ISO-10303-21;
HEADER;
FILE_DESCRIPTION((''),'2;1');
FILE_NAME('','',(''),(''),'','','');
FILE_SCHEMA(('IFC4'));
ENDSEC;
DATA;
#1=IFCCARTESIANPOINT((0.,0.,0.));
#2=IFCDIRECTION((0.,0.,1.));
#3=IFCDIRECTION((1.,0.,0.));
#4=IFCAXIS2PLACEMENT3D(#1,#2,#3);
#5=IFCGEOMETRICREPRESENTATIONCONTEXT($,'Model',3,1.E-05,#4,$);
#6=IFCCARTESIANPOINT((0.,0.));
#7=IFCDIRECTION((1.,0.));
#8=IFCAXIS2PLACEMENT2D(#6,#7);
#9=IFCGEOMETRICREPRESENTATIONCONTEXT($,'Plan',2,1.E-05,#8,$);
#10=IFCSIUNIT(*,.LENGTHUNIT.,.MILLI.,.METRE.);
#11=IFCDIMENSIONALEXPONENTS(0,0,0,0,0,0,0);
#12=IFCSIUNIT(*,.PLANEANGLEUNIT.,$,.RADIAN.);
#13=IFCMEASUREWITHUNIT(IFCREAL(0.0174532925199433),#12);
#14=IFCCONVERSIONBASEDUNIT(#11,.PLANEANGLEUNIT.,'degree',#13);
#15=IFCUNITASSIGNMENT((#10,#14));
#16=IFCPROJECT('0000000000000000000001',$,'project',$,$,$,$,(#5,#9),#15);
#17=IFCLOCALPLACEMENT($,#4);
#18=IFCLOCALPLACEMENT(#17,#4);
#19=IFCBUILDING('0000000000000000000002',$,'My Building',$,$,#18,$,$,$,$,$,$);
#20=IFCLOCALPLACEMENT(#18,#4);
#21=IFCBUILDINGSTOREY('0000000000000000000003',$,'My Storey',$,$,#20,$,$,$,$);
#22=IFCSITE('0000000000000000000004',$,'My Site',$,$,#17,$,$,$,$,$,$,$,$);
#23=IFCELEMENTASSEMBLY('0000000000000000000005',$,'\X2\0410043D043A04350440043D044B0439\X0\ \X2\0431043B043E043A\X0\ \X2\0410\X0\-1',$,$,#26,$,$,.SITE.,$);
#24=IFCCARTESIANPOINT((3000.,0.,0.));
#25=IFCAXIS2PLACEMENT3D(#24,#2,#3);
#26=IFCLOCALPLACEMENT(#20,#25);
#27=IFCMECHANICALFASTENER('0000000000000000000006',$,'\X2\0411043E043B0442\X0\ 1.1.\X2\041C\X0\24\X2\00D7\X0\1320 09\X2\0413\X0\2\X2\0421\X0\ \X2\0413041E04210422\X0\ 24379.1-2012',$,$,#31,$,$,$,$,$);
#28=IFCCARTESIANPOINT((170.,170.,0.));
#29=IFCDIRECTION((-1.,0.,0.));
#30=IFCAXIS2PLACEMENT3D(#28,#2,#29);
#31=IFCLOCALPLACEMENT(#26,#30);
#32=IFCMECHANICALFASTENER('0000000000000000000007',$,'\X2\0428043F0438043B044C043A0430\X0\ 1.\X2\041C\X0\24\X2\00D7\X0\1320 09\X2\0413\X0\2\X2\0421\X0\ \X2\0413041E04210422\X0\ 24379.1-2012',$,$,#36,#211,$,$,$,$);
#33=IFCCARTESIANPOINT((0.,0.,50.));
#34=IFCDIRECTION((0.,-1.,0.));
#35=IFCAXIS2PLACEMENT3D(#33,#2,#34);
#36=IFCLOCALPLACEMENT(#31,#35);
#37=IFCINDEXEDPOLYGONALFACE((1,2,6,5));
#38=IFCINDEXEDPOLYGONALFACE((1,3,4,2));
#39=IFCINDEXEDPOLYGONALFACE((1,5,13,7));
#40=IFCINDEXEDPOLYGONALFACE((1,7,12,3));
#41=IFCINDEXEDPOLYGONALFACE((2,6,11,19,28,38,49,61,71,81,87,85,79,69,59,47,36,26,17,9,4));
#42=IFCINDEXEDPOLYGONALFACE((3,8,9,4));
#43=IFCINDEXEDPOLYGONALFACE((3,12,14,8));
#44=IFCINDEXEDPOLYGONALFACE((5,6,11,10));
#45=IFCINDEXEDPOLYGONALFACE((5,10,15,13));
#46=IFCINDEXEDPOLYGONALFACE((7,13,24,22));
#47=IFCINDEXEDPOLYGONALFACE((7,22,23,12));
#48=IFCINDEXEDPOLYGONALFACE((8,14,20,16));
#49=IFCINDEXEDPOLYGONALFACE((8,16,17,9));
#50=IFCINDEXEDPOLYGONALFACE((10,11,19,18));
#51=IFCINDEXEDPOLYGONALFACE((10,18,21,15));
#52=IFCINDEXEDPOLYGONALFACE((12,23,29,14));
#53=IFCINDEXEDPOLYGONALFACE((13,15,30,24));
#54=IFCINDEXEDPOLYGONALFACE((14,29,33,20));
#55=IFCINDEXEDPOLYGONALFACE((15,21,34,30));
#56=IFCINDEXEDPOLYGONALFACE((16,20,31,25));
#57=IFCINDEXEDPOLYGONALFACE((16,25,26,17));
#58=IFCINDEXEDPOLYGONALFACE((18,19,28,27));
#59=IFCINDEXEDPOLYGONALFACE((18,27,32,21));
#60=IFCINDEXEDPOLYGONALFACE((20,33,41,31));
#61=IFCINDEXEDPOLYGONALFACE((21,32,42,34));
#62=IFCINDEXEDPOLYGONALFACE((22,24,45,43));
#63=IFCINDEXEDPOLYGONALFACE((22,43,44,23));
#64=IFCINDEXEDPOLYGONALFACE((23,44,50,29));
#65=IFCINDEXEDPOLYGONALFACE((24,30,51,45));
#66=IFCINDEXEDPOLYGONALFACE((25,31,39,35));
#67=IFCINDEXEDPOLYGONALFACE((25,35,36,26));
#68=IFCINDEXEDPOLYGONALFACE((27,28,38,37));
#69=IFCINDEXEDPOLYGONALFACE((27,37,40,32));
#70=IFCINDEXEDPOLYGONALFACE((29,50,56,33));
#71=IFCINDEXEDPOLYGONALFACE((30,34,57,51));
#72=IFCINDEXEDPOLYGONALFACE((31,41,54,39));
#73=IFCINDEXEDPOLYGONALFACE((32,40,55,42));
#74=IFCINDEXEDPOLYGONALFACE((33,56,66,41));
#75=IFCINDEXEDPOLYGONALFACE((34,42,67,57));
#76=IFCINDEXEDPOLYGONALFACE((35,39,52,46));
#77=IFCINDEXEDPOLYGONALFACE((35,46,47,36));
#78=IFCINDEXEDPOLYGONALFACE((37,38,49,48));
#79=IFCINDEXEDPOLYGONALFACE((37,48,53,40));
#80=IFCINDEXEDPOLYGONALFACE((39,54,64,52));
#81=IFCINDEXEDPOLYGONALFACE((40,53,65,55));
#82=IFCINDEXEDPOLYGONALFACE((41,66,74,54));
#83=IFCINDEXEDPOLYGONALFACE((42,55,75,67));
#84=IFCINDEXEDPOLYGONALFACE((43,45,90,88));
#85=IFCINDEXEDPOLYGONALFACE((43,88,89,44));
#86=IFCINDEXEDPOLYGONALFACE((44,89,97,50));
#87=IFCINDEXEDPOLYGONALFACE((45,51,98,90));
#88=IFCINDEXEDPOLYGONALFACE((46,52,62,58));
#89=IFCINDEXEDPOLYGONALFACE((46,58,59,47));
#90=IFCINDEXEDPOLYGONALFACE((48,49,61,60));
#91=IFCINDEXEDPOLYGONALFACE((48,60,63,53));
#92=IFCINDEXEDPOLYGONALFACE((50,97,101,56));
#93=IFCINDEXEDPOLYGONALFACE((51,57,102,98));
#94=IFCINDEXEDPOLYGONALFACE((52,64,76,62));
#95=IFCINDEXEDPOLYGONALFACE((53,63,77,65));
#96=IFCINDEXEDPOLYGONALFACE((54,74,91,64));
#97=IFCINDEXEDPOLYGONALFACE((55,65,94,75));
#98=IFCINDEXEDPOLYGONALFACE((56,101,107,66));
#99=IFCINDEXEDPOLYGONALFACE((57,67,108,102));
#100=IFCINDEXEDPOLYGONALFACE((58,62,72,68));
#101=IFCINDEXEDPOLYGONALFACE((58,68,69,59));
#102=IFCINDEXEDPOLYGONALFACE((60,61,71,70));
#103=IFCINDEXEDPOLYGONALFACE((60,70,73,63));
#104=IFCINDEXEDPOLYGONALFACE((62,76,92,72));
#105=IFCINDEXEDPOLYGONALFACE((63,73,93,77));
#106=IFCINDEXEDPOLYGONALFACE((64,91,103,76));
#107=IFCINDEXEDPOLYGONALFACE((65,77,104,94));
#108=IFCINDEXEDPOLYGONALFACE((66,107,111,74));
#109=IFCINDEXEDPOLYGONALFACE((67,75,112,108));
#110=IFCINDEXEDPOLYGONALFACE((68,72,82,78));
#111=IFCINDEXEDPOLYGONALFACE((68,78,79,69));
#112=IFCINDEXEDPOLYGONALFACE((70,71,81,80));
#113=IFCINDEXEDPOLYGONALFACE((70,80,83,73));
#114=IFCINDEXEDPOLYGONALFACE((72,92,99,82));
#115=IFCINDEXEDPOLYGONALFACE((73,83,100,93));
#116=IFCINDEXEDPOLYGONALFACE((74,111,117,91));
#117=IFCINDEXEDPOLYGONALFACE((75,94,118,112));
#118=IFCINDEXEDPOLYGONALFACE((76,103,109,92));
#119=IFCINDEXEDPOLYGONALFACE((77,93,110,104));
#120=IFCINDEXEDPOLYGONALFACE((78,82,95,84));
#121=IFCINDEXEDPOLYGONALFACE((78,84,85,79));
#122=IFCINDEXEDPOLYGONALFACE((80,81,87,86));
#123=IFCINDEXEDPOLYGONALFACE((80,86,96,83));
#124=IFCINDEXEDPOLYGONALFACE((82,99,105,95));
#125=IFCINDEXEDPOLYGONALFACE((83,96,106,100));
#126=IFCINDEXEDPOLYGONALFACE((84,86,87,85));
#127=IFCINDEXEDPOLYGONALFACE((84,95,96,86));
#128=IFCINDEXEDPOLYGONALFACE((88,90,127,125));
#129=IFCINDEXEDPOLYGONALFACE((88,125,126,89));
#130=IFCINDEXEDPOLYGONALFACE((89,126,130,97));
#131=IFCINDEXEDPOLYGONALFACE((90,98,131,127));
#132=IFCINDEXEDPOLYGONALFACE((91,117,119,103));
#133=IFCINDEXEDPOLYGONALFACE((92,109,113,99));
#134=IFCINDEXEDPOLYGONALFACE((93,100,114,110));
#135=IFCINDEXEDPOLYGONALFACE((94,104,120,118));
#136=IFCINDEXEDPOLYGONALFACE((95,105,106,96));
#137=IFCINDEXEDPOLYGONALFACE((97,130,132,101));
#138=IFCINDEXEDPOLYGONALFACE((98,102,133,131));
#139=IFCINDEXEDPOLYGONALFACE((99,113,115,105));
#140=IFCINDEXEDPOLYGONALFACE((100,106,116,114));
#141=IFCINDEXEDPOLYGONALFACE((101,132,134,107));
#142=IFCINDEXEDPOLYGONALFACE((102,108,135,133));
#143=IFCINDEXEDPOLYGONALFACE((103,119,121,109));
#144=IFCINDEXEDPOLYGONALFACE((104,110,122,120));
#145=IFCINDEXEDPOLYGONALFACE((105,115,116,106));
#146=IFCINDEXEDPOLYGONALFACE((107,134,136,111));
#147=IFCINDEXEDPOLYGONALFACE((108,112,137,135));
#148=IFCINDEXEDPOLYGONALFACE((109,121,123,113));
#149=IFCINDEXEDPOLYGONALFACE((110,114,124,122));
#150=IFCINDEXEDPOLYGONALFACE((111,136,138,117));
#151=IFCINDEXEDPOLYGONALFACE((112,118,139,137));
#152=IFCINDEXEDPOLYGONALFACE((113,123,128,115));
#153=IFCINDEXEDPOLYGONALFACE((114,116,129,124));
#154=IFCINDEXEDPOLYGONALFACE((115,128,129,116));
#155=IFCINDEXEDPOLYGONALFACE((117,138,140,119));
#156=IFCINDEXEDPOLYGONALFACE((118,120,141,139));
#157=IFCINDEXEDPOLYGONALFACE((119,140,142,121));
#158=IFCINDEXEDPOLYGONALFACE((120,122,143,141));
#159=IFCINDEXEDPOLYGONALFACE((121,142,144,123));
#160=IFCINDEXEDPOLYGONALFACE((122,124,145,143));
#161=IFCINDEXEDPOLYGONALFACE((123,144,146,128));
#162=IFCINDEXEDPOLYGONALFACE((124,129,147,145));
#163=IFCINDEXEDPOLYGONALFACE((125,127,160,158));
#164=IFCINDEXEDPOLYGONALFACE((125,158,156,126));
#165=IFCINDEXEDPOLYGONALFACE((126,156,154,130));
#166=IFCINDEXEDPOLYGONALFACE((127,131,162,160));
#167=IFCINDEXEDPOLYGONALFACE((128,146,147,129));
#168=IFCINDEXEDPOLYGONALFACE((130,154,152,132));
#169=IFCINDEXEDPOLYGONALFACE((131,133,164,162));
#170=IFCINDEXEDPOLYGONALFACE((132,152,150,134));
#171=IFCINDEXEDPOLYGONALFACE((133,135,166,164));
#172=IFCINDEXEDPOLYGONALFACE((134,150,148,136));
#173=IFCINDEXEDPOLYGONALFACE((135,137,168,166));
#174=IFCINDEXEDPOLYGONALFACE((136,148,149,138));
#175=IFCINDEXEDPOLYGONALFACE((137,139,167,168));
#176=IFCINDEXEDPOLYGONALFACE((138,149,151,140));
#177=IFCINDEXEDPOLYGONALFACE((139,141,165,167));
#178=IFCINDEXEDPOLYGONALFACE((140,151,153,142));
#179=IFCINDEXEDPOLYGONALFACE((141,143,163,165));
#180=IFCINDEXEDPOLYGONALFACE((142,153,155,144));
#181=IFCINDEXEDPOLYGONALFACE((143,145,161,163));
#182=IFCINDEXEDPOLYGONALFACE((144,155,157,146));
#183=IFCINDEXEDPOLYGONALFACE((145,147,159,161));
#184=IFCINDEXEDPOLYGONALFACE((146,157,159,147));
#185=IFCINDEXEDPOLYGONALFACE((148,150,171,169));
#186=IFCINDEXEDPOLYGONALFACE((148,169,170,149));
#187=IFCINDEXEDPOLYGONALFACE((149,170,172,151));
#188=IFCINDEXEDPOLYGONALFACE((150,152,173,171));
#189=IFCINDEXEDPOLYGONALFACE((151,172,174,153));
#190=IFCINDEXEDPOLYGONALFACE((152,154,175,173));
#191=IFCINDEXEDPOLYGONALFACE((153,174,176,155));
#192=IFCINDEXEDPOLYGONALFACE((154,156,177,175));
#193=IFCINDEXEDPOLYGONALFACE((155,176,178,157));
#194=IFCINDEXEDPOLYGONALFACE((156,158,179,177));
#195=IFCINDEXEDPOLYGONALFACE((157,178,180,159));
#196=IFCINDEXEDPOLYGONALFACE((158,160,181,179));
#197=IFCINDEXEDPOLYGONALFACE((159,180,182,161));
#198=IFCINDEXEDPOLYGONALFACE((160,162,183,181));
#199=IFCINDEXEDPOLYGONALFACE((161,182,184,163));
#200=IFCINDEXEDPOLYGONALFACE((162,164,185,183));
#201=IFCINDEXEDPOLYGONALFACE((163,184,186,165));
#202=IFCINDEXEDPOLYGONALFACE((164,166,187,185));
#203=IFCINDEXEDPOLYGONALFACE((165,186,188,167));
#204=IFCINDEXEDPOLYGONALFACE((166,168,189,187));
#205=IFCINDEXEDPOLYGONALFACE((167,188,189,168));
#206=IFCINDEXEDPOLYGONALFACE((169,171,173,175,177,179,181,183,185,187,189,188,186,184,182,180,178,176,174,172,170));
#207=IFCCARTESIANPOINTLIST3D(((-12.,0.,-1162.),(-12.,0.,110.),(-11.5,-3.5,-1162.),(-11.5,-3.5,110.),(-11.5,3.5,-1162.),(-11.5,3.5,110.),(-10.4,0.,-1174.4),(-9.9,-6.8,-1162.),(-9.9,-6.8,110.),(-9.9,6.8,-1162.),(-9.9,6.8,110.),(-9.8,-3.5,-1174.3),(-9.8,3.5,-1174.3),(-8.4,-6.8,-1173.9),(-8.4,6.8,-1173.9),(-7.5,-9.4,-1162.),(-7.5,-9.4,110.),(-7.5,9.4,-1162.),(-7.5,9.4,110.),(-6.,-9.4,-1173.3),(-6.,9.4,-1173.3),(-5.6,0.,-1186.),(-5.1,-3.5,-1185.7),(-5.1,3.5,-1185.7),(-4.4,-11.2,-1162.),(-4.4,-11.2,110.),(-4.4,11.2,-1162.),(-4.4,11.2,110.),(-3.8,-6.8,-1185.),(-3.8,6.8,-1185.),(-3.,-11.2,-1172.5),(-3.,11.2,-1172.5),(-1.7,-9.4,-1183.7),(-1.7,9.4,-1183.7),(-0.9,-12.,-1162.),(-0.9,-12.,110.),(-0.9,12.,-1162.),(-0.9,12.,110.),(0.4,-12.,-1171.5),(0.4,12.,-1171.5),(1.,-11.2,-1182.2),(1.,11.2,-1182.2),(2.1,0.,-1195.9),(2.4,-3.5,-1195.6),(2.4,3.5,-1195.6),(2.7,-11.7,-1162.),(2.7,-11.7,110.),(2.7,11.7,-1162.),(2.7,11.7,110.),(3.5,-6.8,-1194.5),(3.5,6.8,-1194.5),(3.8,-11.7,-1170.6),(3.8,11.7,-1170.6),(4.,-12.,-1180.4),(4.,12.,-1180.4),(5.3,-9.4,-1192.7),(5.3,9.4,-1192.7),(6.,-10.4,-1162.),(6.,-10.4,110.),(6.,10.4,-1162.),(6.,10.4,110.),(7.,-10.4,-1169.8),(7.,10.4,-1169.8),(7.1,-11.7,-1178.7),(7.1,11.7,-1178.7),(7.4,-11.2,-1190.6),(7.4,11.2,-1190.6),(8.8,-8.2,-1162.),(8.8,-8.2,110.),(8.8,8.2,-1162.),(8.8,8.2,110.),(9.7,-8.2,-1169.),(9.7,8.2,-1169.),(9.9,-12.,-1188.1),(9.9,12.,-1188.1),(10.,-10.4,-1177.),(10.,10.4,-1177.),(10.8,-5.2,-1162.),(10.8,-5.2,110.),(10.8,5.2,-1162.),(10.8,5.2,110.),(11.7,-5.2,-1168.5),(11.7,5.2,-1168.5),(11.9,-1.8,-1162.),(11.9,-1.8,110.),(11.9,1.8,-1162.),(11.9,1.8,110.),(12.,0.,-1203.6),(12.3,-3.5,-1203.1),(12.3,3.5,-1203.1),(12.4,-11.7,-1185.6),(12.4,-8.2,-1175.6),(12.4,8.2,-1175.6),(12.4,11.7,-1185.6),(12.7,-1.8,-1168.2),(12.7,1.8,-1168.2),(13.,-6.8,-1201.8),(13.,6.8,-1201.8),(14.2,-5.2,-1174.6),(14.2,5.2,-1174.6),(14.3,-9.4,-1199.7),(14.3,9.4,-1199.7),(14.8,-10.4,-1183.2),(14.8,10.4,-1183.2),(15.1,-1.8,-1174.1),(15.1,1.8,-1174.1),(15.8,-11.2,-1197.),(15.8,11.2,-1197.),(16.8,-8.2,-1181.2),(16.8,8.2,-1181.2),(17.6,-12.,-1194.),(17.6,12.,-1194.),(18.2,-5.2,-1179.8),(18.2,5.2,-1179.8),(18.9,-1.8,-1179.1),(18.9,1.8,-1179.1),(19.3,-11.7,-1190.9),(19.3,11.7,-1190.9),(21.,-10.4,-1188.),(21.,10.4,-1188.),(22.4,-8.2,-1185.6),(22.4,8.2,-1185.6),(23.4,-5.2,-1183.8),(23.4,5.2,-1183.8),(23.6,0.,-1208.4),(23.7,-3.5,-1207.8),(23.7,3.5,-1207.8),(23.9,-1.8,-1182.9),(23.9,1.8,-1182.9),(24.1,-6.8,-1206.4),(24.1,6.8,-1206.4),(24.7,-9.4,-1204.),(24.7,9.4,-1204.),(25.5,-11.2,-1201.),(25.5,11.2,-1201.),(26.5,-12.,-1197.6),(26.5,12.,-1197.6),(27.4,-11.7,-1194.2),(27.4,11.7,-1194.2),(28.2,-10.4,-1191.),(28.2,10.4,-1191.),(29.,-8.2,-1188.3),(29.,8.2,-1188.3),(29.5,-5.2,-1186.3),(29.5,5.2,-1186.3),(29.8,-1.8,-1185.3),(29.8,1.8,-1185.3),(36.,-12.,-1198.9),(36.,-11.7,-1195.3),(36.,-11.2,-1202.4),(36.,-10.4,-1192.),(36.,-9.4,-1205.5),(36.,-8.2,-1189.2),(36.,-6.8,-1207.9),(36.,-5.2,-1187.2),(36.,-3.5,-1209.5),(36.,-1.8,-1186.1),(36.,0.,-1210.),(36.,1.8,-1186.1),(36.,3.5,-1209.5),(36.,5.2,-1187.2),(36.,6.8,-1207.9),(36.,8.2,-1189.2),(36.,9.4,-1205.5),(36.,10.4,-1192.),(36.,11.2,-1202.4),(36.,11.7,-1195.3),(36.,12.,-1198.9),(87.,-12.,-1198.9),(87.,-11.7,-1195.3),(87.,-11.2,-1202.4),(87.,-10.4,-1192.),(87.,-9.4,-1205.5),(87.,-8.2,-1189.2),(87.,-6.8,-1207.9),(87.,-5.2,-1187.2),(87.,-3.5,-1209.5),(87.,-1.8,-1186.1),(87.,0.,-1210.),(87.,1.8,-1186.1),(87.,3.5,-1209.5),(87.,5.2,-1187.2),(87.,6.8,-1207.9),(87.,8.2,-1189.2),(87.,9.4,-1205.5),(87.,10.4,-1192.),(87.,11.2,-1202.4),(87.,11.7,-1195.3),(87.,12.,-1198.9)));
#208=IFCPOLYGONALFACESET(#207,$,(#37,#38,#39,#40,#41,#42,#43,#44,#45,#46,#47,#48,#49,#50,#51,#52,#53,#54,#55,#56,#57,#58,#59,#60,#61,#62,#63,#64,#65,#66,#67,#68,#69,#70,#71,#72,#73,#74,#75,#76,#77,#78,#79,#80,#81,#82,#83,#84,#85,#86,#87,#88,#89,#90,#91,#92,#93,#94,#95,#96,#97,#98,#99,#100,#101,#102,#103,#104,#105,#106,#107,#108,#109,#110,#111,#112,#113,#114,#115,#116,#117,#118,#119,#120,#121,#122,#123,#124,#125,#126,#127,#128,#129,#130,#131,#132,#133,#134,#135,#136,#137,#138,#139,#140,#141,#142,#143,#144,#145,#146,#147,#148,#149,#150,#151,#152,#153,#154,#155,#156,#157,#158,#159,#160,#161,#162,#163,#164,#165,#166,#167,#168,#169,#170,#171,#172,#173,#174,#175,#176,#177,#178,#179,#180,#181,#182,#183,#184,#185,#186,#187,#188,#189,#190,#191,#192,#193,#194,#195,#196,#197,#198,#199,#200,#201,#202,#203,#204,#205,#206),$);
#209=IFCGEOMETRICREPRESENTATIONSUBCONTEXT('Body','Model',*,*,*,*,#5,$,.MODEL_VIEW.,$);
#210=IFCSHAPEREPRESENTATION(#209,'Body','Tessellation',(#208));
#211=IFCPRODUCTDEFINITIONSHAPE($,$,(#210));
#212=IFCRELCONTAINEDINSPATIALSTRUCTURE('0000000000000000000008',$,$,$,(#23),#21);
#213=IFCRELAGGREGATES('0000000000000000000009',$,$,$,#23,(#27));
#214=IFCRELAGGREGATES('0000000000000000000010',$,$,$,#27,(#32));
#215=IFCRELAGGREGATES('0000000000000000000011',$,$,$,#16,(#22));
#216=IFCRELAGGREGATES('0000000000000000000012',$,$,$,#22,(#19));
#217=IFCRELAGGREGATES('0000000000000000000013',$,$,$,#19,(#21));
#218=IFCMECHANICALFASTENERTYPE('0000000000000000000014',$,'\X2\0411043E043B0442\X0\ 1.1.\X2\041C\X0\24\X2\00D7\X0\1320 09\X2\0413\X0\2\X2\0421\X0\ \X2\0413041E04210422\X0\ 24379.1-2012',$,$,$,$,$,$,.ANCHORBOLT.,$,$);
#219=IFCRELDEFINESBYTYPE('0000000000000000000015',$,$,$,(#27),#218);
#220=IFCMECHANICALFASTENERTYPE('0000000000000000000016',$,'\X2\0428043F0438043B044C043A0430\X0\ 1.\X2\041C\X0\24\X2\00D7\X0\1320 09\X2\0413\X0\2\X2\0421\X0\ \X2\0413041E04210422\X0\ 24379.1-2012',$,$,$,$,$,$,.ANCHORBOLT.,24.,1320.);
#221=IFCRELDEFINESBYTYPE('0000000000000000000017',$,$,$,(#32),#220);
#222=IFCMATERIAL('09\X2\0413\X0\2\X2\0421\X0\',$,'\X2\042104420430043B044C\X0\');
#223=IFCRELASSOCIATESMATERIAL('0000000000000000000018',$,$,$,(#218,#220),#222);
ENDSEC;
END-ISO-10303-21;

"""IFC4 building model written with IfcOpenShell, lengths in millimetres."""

from ifc_helpers import new_model, entity, si_unit, converted_unit, frame, origin_with_axes, origin_2d_with_axis, place, context, subcontext, project, spatial, source, transform, mapped, material, type_object, type_shapes, element, aggregate, save


model = new_model("IFC4")

# Units and contexts
model_context = context("Model", 3, precision=1e-05, world=origin_with_axes())
plan_context = context("Plan", 2, precision=1e-05, world=origin_2d_with_axis())
body_context = subcontext(model_context, "Body", "Model", "MODEL_VIEW")
ifc_project = project(units=[si_unit("LENGTHUNIT", "METRE", prefix="MILLI"), converted_unit("PLANEANGLEUNIT", "degree", entity("IfcReal", 0.0174532925199433), si_unit("PLANEANGLEUNIT", "RADIAN"), dimensions=[0, 0, 0, 0, 0, 0, 0])], contexts=[model_context, plan_context])

# Site, building, storey
site_placement = place(None, origin_with_axes())
site = spatial("IfcSite", under=ifc_project, at=site_placement, Name="My Site")
building_placement = place(site_placement, origin_with_axes())
building = spatial("IfcBuilding", under=site, at=building_placement, Name="My Building")
storey_placement = place(building_placement, origin_with_axes())
storey = spatial("IfcBuildingStorey", under=building, at=storey_placement, Name="My Storey")

# Element assembly
placement_1 = place(storey_placement, frame((3000.0, 0.0, 0.0), z_axis=(0.0, 0.0, 1.0), x_axis=(1.0, 0.0, 0.0)))
assembly_1 = element("IfcElementAssembly", 1, at=placement_1, inside=storey, Name="Анкерный блок А-1", AssemblyPlace="SITE")

# Shared definitions
ifc_material_1 = material(Name="09Г2С", Category="Сталь")
mechanical_fastener_type_1 = type_object("IfcMechanicalFastenerType", Name="Болт 1.1.М24×1320 09Г2С ГОСТ 24379.1-2012", PredefinedType="ANCHORBOLT", material=ifc_material_1)
mechanical_fastener_type_2 = type_object("IfcMechanicalFastenerType", Name="Шпилька 1.М24×1320 09Г2С ГОСТ 24379.1-2012", NominalDiameter=24.0, NominalLength=1320.0, PredefinedType="ANCHORBOLT", material=ifc_material_1)
shared_shape_1 = source(frame((0.0, 0.0, 110.0), z_axis=(0.0, 0.0, 1.0), x_axis=(1.0, 0.0, 0.0)), body_context, "Body", "AdvancedSweptSolid", [
    entity("IfcSweptDiskSolid", entity("IfcIndexedPolyCurve", entity("IfcCartesianPointList3D", [[0.0, 0.0, 0.0], [0.0, 0.0, -1272.0], [10.5, 0.0, -1297.5], [36.0, 0.0, -1308.0], [87.0, 0.0, -1308.0]]), [entity("IfcLineIndex", [1, 2]), entity("IfcArcIndex", [2, 3, 4]), entity("IfcLineIndex", [4, 5])]), 12.0),
])
type_shapes(mechanical_fastener_type_2, [shared_shape_1])

# Mechanical fasteners
mechanical_fastener_1_placement = place(placement_1, frame((170.0, 170.0, 0.0), z_axis=(0.0, 0.0, 1.0), x_axis=(-1.0, 0.0, 0.0)))
mechanical_fastener_1 = element("IfcMechanicalFastener", 2, at=mechanical_fastener_1_placement, type_object=mechanical_fastener_type_1, Name="Болт 1.1.М24×1320 09Г2С ГОСТ 24379.1-2012")
aggregate(assembly_1, [mechanical_fastener_1])
mechanical_fastener_2_placement = place(mechanical_fastener_1_placement, frame((0.0, 0.0, 50.0), z_axis=(0.0, 0.0, 1.0), x_axis=(0.0, -1.0, 0.0)))
mechanical_fastener_2 = element("IfcMechanicalFastener", 3, at=mechanical_fastener_2_placement, type_object=mechanical_fastener_type_2, Name="Шпилька 1.М24×1320 09Г2С ГОСТ 24379.1-2012", context=body_context, shape_type="MappedRepresentation", body=[
    mapped(shared_shape_1, transform((0.0, 0.0, 0.0), x_axis=(1.0, 0.0, 0.0), y_axis=(0.0, 1.0, 0.0), z_axis=(0.0, 0.0, 1.0), scale=1.0)),
])
aggregate(mechanical_fastener_1, [mechanical_fastener_2])

save(model, "model.ifc")
